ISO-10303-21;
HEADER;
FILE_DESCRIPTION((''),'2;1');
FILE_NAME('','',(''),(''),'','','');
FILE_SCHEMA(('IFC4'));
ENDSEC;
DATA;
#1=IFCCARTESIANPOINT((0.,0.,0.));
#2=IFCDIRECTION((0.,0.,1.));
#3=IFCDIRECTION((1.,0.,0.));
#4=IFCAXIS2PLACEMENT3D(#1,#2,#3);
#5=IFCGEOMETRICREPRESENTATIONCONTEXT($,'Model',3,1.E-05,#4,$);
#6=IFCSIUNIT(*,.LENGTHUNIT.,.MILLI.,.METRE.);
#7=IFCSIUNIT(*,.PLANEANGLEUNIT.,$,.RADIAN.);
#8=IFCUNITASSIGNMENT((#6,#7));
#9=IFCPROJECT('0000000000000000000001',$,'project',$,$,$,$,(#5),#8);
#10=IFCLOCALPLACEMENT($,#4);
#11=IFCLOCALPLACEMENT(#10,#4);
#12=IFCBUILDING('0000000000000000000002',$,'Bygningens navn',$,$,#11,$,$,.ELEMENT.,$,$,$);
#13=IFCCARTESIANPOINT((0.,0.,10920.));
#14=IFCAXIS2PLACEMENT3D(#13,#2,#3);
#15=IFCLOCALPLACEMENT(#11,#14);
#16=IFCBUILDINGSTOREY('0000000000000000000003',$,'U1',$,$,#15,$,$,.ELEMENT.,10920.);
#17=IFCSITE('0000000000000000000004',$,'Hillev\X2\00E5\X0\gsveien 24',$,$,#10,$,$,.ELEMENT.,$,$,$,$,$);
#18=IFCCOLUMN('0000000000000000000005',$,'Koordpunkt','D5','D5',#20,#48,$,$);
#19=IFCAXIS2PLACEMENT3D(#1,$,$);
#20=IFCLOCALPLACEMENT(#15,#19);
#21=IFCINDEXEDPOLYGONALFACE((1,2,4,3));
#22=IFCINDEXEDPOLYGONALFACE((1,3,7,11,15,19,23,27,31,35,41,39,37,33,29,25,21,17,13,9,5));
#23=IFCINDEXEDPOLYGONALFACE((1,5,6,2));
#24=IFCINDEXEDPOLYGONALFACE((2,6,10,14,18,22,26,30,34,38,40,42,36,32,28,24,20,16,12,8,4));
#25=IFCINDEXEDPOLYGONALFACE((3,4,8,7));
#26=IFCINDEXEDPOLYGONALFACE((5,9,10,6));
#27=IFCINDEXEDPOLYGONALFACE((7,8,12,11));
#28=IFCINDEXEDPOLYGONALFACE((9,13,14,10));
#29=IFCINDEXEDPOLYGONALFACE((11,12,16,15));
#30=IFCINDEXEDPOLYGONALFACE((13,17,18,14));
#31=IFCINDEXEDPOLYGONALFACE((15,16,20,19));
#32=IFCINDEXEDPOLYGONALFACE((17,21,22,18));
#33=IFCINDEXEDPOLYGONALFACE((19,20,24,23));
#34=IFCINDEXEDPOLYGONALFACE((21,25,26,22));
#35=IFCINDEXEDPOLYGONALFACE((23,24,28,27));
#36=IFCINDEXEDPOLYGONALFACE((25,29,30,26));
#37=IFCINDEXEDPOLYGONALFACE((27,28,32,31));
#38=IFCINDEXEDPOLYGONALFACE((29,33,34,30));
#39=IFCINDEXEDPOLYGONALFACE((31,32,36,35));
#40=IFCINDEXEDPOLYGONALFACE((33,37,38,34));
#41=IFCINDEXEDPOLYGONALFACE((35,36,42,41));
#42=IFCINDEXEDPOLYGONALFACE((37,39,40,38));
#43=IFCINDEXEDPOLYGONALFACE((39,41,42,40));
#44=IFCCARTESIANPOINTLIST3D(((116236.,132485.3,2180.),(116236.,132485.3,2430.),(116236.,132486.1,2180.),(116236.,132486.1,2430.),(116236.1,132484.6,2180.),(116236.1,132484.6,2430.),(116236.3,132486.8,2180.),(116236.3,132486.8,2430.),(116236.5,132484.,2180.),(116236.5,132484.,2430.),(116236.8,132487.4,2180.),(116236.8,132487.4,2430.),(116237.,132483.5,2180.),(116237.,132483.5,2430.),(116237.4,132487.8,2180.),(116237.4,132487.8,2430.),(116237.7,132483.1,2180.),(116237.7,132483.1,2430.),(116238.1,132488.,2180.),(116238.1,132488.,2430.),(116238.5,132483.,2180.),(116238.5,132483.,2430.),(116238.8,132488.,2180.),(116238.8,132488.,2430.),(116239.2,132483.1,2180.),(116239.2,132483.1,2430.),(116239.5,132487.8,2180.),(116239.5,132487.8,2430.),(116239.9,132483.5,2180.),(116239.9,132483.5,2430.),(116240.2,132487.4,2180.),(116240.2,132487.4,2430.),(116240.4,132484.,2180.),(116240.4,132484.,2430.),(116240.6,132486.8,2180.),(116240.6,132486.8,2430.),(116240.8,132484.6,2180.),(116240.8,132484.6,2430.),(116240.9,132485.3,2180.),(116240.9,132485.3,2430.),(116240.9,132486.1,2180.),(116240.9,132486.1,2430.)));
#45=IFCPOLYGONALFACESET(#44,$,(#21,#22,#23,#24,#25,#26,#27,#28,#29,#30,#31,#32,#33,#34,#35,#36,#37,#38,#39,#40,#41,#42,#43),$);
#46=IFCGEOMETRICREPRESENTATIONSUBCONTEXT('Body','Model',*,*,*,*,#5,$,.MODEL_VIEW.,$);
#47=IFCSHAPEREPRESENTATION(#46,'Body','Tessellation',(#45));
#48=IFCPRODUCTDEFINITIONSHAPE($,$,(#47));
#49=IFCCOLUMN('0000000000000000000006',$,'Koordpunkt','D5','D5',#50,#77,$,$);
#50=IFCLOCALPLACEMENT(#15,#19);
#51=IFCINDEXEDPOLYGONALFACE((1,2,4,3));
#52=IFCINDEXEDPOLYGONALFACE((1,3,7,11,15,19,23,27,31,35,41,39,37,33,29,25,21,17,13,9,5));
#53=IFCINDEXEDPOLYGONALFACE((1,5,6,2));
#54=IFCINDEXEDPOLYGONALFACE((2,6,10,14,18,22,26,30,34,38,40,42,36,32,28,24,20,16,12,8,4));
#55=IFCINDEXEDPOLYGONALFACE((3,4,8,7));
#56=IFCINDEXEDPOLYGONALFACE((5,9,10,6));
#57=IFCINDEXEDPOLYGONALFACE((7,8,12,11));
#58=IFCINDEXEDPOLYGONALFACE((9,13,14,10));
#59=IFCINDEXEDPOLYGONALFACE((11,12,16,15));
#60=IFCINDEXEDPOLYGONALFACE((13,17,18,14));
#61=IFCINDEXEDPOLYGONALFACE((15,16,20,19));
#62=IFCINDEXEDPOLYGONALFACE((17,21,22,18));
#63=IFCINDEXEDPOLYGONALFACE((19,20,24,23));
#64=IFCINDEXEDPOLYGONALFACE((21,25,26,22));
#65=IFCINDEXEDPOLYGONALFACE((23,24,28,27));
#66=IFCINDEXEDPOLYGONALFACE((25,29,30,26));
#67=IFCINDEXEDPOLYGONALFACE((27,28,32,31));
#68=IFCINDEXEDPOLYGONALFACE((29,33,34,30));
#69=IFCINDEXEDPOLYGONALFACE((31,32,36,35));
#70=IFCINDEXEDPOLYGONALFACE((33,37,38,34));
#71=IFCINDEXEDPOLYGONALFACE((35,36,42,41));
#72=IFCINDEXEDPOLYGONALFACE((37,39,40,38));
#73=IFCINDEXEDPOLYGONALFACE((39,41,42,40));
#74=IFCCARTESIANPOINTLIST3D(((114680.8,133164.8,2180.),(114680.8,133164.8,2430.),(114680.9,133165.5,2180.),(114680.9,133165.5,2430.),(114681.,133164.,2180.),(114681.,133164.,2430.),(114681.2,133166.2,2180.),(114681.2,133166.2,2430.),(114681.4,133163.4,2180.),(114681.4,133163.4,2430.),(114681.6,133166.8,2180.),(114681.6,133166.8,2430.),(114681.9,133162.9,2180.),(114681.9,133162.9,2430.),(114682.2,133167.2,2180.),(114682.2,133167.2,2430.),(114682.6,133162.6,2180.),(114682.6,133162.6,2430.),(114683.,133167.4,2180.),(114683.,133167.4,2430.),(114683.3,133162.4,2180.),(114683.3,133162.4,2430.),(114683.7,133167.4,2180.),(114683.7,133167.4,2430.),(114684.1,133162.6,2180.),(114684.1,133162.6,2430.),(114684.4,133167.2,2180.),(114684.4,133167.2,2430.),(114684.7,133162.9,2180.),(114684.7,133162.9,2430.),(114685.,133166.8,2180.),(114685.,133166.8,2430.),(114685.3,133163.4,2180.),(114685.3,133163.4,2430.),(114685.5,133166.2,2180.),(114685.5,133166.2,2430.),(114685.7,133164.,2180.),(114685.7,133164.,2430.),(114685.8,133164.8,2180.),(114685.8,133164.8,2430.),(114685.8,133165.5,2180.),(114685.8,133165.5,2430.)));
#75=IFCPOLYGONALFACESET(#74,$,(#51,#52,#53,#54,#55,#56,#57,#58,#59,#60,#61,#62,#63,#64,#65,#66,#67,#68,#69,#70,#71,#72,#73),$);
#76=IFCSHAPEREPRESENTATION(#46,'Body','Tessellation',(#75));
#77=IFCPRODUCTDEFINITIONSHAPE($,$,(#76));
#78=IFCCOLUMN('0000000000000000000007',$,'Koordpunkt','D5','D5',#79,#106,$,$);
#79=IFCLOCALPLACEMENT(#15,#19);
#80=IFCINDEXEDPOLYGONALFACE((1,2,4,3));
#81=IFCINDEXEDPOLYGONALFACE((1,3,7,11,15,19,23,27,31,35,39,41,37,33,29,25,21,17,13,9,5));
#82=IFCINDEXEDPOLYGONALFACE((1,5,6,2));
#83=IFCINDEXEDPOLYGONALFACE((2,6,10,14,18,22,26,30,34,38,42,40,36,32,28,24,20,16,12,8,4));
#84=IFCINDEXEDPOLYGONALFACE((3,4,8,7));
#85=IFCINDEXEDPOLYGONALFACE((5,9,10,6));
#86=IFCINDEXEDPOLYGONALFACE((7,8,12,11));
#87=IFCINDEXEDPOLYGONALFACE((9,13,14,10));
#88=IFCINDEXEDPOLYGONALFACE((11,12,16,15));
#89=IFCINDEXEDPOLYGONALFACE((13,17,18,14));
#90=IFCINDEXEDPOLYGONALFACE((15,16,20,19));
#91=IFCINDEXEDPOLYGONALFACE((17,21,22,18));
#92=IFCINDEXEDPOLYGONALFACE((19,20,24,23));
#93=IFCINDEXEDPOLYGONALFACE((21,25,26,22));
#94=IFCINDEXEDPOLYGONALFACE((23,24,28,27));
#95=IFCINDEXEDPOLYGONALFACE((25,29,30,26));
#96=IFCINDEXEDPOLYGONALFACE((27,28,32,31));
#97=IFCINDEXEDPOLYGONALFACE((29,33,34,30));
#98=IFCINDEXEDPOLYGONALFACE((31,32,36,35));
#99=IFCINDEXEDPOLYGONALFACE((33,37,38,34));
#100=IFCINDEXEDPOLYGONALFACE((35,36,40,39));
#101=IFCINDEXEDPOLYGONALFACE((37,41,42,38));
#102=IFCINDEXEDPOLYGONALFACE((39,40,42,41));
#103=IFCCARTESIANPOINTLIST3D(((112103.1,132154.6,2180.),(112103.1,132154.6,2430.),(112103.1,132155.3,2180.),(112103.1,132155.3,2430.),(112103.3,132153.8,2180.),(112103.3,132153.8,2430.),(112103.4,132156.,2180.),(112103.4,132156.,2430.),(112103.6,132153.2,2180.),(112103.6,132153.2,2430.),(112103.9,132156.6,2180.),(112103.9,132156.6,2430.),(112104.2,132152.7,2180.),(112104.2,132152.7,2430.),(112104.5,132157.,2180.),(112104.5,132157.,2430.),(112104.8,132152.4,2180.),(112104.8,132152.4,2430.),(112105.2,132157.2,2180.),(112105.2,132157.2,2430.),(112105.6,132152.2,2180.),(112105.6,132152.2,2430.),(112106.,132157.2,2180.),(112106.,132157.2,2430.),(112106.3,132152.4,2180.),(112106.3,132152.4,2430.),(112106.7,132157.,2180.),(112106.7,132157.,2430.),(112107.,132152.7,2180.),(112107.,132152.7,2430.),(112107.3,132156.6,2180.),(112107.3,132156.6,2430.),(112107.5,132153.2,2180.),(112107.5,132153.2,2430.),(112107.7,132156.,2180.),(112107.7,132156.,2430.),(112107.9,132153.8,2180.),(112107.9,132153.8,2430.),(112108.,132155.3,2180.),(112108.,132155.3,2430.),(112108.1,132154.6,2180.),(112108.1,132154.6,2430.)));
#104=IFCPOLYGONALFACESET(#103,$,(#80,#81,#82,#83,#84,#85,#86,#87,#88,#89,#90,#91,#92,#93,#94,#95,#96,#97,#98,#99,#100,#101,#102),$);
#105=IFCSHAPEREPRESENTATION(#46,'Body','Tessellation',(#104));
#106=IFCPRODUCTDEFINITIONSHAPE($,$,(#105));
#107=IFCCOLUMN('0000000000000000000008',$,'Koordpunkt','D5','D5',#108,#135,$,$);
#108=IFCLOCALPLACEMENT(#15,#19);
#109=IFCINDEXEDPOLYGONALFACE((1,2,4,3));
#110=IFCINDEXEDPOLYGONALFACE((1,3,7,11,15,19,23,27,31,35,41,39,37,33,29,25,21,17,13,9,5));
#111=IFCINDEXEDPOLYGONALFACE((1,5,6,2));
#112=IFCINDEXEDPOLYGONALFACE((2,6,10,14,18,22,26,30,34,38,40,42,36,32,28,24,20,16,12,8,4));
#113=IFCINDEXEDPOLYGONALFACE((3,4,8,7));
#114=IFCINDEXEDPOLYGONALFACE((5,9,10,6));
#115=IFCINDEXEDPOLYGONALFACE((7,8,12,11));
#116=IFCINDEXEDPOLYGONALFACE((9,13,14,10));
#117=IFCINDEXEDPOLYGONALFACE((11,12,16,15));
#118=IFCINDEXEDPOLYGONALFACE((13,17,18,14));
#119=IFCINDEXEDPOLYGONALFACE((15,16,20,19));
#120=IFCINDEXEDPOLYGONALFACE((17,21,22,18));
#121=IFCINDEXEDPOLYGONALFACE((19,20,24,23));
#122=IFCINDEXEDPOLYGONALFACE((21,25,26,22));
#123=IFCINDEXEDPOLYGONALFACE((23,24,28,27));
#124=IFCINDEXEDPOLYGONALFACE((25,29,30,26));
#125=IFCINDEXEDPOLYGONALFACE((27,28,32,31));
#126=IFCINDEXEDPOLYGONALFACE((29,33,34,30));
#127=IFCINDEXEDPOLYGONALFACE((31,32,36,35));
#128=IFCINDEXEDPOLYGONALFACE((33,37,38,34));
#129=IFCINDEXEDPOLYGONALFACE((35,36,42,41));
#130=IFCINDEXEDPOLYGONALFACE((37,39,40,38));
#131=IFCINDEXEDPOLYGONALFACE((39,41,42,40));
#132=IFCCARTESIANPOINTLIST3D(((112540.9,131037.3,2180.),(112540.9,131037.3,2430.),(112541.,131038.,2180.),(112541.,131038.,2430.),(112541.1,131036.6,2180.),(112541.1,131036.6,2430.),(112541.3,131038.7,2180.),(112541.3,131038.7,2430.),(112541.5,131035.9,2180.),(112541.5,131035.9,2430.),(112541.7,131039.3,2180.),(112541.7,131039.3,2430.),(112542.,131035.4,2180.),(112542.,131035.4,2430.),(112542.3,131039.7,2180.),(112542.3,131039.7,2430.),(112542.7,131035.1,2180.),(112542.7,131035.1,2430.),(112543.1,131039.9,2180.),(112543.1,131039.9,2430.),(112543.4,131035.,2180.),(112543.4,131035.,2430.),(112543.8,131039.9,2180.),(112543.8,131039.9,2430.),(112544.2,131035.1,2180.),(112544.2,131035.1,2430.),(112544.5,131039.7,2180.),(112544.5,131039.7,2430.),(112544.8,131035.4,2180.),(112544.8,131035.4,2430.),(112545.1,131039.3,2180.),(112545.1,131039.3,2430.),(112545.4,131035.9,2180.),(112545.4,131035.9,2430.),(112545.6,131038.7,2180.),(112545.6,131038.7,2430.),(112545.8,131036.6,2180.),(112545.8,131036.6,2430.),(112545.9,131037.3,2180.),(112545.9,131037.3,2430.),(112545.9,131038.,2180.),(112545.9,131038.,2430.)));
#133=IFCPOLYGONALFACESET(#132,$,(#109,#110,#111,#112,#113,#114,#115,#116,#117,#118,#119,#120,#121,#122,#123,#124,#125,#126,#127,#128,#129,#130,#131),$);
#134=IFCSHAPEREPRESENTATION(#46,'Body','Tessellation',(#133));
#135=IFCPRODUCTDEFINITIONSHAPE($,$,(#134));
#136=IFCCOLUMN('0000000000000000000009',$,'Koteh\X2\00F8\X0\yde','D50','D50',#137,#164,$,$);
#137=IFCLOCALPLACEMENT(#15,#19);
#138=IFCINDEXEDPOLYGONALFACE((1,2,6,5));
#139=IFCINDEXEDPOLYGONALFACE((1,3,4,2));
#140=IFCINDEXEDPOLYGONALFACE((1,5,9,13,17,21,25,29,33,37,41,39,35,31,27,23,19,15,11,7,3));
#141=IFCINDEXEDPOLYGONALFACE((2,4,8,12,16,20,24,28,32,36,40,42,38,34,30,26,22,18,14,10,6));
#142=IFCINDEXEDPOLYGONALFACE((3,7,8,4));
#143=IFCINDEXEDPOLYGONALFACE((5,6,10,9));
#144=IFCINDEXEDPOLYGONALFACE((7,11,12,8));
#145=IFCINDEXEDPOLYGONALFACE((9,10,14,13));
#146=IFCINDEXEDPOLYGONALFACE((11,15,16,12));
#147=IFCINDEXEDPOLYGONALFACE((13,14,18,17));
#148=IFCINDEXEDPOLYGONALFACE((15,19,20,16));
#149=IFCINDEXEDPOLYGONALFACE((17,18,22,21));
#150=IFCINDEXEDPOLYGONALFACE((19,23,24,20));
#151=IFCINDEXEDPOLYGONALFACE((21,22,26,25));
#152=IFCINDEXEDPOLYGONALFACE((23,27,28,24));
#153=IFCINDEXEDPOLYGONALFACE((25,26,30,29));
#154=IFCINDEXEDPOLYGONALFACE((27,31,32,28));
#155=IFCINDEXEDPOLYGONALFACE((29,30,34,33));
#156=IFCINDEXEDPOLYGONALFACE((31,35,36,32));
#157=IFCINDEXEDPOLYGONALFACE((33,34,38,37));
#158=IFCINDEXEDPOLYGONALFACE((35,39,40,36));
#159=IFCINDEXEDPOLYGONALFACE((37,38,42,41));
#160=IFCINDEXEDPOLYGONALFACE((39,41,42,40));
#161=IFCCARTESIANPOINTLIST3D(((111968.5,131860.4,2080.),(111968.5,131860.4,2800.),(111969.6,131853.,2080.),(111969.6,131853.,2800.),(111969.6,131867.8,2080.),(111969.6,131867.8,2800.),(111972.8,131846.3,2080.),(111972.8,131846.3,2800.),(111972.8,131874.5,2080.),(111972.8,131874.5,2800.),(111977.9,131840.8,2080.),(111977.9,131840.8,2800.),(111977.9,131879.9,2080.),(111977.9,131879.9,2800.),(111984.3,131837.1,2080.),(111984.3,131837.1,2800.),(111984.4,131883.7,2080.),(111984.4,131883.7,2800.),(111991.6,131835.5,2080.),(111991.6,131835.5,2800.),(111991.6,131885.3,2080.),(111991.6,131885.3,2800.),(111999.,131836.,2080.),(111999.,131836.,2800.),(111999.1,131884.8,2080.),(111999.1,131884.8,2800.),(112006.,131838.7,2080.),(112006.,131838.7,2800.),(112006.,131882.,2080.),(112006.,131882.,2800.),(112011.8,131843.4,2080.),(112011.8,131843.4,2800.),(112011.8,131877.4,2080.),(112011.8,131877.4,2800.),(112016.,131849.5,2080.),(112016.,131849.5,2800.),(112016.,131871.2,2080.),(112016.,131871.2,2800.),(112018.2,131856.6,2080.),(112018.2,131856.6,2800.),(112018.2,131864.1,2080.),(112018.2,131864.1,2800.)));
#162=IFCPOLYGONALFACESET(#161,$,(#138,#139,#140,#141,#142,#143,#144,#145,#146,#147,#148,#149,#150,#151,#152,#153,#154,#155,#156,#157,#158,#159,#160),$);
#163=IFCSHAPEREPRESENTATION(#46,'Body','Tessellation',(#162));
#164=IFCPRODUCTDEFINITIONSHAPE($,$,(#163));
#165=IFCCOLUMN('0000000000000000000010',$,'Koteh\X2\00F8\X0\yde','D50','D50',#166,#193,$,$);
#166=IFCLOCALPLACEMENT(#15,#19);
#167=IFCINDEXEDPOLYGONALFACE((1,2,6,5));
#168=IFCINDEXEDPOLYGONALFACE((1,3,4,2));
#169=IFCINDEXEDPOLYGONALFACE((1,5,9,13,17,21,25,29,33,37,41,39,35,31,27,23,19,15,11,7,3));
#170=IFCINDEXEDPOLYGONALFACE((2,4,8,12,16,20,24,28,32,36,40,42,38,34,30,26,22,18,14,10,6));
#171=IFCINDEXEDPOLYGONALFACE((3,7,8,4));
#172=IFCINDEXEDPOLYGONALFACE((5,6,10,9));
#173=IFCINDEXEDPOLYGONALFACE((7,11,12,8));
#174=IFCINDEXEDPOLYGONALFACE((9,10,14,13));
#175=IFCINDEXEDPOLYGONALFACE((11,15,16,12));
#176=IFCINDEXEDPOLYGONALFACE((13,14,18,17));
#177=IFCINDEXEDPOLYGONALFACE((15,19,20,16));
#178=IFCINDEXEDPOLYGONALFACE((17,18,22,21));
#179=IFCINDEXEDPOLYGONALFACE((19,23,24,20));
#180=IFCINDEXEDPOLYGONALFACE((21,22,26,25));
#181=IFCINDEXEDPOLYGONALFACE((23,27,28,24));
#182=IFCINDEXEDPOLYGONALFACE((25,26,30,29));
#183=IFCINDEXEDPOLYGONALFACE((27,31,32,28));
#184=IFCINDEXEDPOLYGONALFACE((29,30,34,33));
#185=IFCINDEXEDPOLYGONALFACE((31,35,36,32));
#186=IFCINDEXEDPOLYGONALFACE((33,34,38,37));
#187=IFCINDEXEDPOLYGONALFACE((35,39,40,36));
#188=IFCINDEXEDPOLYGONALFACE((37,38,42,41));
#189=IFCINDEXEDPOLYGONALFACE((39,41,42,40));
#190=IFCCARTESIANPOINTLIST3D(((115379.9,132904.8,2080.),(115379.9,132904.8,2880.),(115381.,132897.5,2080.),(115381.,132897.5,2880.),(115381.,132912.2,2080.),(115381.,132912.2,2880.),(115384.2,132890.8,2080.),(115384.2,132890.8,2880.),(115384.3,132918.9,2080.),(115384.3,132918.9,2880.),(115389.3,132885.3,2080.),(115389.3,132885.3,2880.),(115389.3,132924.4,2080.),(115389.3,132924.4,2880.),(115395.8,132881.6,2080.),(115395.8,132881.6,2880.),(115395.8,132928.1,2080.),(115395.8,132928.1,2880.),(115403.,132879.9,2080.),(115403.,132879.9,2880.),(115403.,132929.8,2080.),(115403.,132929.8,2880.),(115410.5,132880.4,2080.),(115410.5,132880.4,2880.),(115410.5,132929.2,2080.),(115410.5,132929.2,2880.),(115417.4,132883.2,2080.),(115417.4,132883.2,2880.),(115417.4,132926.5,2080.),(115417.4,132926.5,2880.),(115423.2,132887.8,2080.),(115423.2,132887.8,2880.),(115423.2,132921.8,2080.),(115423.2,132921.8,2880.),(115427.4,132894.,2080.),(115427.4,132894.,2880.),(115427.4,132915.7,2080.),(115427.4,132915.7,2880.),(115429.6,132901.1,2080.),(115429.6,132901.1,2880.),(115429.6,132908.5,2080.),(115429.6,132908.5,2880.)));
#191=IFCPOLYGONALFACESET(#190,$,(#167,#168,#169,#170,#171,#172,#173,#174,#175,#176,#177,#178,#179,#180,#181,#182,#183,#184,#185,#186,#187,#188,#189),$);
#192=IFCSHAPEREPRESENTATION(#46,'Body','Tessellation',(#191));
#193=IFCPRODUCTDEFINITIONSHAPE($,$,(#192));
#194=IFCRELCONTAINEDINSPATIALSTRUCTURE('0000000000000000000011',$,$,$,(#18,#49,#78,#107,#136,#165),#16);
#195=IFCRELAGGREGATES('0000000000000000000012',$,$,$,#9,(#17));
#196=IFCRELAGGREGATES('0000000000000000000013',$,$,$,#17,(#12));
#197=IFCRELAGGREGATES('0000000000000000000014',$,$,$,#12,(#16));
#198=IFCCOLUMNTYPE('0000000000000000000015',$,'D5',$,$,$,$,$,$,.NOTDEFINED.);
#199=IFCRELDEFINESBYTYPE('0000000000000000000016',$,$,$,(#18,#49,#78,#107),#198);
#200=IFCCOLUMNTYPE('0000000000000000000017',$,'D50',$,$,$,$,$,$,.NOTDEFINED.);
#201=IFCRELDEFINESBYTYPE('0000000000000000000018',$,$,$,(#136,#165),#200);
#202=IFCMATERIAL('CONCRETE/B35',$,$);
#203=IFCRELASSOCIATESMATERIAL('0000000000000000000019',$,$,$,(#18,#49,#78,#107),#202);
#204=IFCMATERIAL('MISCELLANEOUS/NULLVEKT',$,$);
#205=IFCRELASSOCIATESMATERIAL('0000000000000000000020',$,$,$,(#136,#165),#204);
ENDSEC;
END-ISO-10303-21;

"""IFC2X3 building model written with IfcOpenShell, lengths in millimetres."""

from ifc_helpers import new_model, si_unit, frame, frame_2d, origin_with_axes, place, context, subcontext, project, spatial, circle, extrude, material, type_object, element, save


model = new_model("IFC2X3")

# Units and contexts
model_context = context("Model", 3, precision=1e-05, world=origin_with_axes())
body_context = subcontext(model_context, "Body", "Model", "MODEL_VIEW")
ifc_project = project(units=[si_unit("LENGTHUNIT", "METRE", prefix="MILLI"), si_unit("PLANEANGLEUNIT", "RADIAN")], contexts=[model_context])

# Site, building, storey
site_placement = place(None, origin_with_axes())
site = spatial("IfcSite", under=ifc_project, at=site_placement, Name="Hillevågsveien 24", CompositionType="ELEMENT")
building_placement = place(site_placement, origin_with_axes())
building = spatial("IfcBuilding", under=site, at=building_placement, Name="Bygningens navn", CompositionType="ELEMENT")
storey_placement = place(building_placement, frame((0.0, 0.0, 10920.0), z_axis=(0.0, 0.0, 1.0), x_axis=(1.0, 0.0, 0.0)))
storey = spatial("IfcBuildingStorey", under=building, at=storey_placement, Name="U1", CompositionType="ELEMENT", Elevation=10920.0)

# Columns
ifc_material_1 = material(Name="CONCRETE/B35")
column_type_1 = type_object("IfcColumnType", Name="D5", PredefinedType="NOTDEFINED")
for number, where, z_axis, x_axis, name in (
    (1, (116238.5, 132485.5, 2180.0), (0.0, 0.0, 1.0), (-1.0, 0.0, 0.0), "Koordpunkt"),
    (2, (114683.3, 133164.9, 2180.0), (0.0, 0.0, 1.0), (-1.0, 0.0, 0.0), "Koordpunkt"),
    (3, (112105.6, 132154.7, 2180.0), (0.0, 0.0, 1.0), (-1.0, 0.0, 0.0), "Koordpunkt"),
    (4, (112543.4, 131037.5, 2180.0), (0.0, 0.0, 1.0), (-1.0, 0.0, 0.0), "Koordpunkt"),
):
    element("IfcColumn", number, at=place(storey_placement, frame(where, z_axis=z_axis, x_axis=x_axis)), inside=storey, type_object=column_type_1, material=ifc_material_1, Name=name, Description="D5", ObjectType="D5", context=body_context, shape_type="SweptSolid", body=[
        extrude(circle(Radius=2.5, at=frame_2d((0.0, 0.0), x_axis=(1.0, 0.0))), frame((0.0, 0.0, 250.0), z_axis=(0.0, 0.0, -1.0), x_axis=(0.0, 1.0, 0.0)), (0.0, 0.0, 1.0), 250.0),
    ])
ifc_material_2 = material(Name="MISCELLANEOUS/NULLVEKT")
column_type_2 = type_object("IfcColumnType", Name="D50", PredefinedType="NOTDEFINED")
column_1_placement = place(storey_placement, frame((111993.5, 131860.4, 2080.0), z_axis=(0.0, 0.0, 1.0), x_axis=(0.931056, 0.364877, 0.0)))
element("IfcColumn", 5, at=column_1_placement, inside=storey, type_object=column_type_2, material=ifc_material_2, Name="Kotehøyde", Description="D50", ObjectType="D50", context=body_context, shape_type="SweptSolid", body=[
    extrude(circle(Radius=25.0, at=frame_2d((0.0, 0.0), x_axis=(1.0, 0.0))), frame((0.0, 0.0, 720.0), z_axis=(0.0, 0.0, -1.0), x_axis=(0.0, 1.0, 0.0)), (0.0, 0.0, 1.0), 720.0),
])
column_2_placement = place(storey_placement, frame((115404.9, 132904.8, 2080.0), z_axis=(0.0, 0.0, 1.0), x_axis=(0.931056, 0.364877, 0.0)))
element("IfcColumn", 6, at=column_2_placement, inside=storey, type_object=column_type_2, material=ifc_material_2, Name="Kotehøyde", Description="D50", ObjectType="D50", context=body_context, shape_type="SweptSolid", body=[
    extrude(circle(Radius=25.0, at=frame_2d((0.0, 0.0), x_axis=(1.0, 0.0))), frame((0.0, 0.0, 800.0), z_axis=(0.0, 0.0, -1.0), x_axis=(0.0, 1.0, 0.0)), (0.0, 0.0, 1.0), 800.0),
])

save(model, "model.ifc")
